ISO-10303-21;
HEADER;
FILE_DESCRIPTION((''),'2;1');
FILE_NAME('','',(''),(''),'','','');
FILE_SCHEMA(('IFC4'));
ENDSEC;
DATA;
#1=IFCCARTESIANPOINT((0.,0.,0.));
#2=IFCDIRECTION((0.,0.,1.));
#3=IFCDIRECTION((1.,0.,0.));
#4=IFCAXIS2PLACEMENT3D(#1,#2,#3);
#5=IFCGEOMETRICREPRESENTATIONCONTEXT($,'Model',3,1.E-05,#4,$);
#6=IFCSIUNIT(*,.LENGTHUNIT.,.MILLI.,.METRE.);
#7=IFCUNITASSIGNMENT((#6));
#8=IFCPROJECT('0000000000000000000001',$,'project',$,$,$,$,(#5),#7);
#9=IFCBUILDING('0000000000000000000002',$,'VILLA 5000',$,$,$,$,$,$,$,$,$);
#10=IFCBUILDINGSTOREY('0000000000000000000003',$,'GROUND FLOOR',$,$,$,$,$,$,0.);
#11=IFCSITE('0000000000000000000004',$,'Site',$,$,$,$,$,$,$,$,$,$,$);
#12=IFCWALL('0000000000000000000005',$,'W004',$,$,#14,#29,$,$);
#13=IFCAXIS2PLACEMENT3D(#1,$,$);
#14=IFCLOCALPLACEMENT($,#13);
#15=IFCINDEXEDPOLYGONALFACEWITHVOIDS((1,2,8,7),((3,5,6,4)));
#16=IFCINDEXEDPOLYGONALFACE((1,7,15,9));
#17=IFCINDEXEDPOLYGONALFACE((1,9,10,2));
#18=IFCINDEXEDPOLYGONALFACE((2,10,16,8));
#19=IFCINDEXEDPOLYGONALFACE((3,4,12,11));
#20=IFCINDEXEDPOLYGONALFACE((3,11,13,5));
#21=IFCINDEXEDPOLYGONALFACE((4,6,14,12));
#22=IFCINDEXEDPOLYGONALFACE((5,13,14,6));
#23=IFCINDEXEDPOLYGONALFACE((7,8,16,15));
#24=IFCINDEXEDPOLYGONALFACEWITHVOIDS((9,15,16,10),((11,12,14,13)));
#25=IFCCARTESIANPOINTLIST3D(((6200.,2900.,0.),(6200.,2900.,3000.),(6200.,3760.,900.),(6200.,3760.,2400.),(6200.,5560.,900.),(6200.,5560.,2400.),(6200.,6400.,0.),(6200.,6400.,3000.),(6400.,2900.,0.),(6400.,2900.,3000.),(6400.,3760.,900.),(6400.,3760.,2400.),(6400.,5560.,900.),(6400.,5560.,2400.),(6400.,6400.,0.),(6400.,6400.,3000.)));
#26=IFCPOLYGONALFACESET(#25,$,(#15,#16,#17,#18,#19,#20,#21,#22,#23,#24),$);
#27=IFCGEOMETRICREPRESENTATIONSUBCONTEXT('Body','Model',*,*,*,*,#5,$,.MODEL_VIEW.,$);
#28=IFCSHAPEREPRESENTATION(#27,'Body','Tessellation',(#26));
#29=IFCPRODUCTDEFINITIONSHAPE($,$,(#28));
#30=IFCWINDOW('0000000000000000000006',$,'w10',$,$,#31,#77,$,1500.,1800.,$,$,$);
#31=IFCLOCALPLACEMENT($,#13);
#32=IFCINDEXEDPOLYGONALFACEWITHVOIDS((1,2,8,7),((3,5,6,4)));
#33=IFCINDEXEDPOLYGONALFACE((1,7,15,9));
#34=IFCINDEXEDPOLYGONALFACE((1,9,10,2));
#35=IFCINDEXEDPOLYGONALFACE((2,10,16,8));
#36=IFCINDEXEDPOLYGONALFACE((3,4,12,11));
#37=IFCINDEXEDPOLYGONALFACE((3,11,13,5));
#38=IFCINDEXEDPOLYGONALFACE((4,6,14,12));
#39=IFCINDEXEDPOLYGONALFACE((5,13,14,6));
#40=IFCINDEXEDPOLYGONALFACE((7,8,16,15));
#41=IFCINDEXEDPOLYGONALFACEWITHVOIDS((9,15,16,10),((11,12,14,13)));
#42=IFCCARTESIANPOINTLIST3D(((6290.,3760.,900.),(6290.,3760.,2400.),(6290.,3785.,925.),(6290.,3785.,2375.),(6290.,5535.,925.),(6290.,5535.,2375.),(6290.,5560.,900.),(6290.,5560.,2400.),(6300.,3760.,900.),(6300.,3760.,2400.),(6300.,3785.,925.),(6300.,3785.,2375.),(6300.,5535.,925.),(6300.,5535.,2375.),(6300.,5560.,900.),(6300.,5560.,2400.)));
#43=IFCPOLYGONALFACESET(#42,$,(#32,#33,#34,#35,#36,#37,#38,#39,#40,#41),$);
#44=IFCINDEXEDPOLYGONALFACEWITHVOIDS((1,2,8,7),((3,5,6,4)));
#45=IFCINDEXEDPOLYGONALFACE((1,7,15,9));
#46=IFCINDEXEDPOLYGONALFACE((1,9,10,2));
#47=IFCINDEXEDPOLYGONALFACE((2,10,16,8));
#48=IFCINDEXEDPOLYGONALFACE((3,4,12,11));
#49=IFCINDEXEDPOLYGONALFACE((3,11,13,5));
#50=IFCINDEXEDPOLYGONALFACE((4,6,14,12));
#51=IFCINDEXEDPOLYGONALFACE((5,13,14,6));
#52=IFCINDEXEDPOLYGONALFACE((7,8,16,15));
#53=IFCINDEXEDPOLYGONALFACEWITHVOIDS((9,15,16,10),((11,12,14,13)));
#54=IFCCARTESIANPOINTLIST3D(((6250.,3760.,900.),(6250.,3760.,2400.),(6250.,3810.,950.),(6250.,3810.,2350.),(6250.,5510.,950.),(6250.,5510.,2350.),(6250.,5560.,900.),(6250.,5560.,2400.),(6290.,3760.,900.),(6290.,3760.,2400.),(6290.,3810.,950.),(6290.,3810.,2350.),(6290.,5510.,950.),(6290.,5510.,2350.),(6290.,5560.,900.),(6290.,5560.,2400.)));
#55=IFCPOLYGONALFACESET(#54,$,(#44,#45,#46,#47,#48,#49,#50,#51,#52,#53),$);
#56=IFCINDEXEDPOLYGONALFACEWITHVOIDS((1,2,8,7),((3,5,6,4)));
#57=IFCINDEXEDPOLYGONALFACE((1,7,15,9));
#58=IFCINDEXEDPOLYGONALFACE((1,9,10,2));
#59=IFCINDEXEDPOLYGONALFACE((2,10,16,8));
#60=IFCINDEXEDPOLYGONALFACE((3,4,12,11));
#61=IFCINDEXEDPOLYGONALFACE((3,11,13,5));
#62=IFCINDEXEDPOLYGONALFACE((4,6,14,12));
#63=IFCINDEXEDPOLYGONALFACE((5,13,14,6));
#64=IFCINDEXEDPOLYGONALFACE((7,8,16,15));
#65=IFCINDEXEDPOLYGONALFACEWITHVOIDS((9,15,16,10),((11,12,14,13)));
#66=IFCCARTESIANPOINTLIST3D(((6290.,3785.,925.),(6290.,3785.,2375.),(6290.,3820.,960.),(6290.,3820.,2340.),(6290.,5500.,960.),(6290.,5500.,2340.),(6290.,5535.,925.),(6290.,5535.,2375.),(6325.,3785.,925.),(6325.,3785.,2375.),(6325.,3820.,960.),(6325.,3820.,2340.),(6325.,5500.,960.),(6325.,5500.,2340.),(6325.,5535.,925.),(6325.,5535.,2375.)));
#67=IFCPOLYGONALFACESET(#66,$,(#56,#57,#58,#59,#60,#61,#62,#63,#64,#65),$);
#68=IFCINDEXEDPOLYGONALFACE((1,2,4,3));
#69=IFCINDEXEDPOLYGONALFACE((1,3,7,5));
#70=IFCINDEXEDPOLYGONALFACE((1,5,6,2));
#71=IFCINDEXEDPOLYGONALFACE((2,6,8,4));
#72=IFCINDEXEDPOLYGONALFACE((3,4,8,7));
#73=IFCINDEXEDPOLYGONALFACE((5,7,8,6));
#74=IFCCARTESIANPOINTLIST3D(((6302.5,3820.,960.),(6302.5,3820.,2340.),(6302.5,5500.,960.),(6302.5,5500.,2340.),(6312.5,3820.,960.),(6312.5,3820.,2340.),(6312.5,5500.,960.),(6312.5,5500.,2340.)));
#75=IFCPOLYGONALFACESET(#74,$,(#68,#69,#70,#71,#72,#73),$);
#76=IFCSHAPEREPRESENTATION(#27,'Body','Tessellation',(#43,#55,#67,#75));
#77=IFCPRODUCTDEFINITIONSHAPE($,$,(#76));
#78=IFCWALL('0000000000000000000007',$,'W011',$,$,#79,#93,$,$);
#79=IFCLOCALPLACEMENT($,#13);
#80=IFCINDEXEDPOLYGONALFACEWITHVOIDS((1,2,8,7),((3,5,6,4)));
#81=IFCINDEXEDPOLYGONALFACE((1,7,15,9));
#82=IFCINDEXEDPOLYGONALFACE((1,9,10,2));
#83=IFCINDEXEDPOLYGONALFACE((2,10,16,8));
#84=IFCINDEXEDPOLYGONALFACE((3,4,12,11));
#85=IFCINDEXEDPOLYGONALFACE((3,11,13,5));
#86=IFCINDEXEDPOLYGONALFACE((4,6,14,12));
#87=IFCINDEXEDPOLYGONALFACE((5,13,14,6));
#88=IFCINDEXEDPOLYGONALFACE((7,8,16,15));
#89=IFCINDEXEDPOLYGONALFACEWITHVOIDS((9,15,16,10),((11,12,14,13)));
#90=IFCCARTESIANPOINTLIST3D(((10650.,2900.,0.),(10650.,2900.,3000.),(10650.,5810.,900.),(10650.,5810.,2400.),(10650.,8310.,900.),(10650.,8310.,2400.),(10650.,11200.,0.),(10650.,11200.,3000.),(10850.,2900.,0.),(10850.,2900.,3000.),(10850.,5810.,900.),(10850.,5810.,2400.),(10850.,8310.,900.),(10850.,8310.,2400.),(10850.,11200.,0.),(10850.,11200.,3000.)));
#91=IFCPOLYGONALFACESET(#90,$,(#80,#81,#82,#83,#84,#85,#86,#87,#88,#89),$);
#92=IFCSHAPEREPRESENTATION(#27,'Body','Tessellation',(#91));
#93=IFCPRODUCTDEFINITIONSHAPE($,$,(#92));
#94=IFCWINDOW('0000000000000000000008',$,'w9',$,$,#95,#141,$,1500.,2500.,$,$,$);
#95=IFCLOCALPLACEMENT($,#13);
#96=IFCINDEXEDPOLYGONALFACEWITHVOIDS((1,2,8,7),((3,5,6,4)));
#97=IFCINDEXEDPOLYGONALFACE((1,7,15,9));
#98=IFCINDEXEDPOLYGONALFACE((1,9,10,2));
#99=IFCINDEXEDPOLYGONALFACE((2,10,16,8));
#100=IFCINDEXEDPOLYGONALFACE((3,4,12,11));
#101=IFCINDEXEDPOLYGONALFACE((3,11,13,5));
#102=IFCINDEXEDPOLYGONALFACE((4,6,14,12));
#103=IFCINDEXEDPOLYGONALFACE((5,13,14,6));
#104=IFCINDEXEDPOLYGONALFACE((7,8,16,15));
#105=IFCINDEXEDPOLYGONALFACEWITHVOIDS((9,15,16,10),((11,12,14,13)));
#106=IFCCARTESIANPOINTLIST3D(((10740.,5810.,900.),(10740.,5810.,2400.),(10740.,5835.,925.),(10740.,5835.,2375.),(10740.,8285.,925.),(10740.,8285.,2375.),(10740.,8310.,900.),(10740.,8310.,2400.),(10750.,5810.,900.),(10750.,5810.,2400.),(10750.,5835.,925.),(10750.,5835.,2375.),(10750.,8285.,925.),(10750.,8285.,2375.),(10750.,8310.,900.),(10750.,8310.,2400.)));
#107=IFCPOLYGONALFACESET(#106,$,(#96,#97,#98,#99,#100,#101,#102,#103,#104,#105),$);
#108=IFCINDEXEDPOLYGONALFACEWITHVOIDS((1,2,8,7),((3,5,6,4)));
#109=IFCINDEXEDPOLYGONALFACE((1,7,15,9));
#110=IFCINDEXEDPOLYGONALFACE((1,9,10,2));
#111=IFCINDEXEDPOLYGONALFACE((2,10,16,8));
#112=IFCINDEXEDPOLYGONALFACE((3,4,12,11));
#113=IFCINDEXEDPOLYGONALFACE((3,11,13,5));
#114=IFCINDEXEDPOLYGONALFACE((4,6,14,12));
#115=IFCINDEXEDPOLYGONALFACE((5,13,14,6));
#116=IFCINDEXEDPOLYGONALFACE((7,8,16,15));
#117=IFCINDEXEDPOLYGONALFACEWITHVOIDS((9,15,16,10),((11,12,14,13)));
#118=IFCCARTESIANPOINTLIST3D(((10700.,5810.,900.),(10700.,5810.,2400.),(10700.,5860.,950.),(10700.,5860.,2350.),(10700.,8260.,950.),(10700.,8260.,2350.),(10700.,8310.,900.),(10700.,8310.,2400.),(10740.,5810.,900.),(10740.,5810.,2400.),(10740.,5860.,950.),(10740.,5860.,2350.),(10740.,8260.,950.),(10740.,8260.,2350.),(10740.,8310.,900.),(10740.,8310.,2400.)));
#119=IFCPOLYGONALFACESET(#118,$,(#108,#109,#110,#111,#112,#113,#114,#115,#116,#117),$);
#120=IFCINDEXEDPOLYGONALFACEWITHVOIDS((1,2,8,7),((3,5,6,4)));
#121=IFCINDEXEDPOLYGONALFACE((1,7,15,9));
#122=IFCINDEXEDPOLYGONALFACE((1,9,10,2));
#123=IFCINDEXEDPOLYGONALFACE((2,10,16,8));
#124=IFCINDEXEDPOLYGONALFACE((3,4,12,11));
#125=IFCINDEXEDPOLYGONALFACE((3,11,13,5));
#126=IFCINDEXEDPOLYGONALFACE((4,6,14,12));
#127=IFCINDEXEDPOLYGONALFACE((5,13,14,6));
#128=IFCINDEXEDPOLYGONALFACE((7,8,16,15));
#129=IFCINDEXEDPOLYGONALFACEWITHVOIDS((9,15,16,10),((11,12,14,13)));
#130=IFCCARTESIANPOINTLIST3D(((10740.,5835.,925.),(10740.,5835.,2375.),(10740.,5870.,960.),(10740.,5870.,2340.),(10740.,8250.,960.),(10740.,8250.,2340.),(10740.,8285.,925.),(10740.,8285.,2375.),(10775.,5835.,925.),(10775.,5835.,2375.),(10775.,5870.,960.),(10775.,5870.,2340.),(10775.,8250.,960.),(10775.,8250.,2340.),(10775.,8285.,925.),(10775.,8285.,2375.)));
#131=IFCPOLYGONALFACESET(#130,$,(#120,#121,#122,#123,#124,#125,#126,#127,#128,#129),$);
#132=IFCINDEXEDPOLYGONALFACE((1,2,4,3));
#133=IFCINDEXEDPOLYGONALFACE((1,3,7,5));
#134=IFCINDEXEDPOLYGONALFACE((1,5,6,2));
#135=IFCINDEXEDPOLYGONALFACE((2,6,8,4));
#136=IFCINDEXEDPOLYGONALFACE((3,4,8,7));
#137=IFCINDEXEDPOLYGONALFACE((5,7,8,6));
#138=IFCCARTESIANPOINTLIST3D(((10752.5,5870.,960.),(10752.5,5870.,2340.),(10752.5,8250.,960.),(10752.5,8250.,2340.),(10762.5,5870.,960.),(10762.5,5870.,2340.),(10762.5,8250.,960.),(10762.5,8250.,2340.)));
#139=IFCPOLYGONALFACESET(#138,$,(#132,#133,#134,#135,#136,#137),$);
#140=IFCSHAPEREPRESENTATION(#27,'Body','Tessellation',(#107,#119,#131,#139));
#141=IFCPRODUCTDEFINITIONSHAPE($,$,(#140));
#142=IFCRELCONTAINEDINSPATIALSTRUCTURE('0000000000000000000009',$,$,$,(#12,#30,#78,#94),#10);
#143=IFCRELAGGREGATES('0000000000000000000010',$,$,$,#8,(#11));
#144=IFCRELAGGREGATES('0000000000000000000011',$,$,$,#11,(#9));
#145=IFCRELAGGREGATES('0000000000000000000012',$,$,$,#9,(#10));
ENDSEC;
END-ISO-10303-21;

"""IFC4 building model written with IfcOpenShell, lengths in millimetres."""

from ifc_helpers import new_model, si_unit, frame, origin_with_axes, place, context, subcontext, project, spatial, line, indexed_curve, outline, extrude, element, fill, save


model = new_model("IFC4")

# Units and contexts
model_context = context("Model", 3, precision=1e-05, world=origin_with_axes())
body_context = subcontext(model_context, "Body", "Model", "MODEL_VIEW")
ifc_project = project(units=[si_unit("LENGTHUNIT", "METRE", prefix="MILLI")], contexts=[model_context])

# Site, building, storey
site = spatial("IfcSite", under=ifc_project, Name="Site")
building = spatial("IfcBuilding", under=site, Name="VILLA 5000")
storey = spatial("IfcBuildingStorey", under=building, Name="GROUND FLOOR", Elevation=0.0)

# Wall, opening, window
wall_1_placement = place(None, frame((6300.0, 6400.0, 0.0), z_axis=(0.0, 0.0, 1.0), x_axis=(0.0, -1.0, 0.0)))
wall_1 = element("IfcWall", 1, at=wall_1_placement, inside=storey, Name="W004", context=body_context, shape_type="SweptSolid", body=[
    extrude(outline(indexed_curve([(0.0, 0.0), (0.0, 200.0), (3500.0, 200.0), (3500.0, 0.0), (0.0, 0.0)], self_intersect=False)), frame((0.0, -100.0, 0.0), z_axis=(0.0, 0.0, 1.0), x_axis=(1.0, 0.0, 0.0)), (0.0, 0.0, 1.0), 3000.0),
])
opening_1_placement = place(wall_1_placement, frame((840.0, 0.0, 900.0), z_axis=(0.0, 0.0, 1.0), x_axis=(1.0, 0.0, 0.0)))
opening_1 = element("IfcOpeningElement", 2, at=opening_1_placement, cuts=wall_1, context=body_context, shape_type="SweptSolid", body=[
    extrude(outline(indexed_curve([(0.0, 0.0), (0.0, 300.0), (1800.0, 300.0), (1800.0, 0.0), (0.0, 0.0)], self_intersect=False)), frame((0.0, -150.0, 0.0), z_axis=(0.0, 0.0, 1.0), x_axis=(1.0, 0.0, 0.0)), (0.0, 0.0, 1.0), 1500.0),
])
window_1_placement = place(None, frame((6200.0, 5560.0, 900.0), z_axis=(0.0, 0.0, 1.0), x_axis=(0.0, -1.0, 0.0)))
window_1 = element("IfcWindow", 3, at=window_1_placement, inside=storey, Name="w10", OverallHeight=1500.0, OverallWidth=1800.0, context=body_context, shape_type="SweptSolid", body=[
    extrude(outline(indexed_curve([(0.0, 0.0), (1800.0, 0.0), (1800.0, 1500.0), (0.0, 1500.0)], segments=[line(1, 2, 3, 4, 1)]), holes=[indexed_curve([(25.0, 25.0), (1775.0, 25.0), (1775.0, 1475.0), (25.0, 1475.0)], segments=[line(1, 2, 3, 4, 1)])]), frame((0.0, 90.0, 0.0), z_axis=(0.0, -1.0, 0.0), x_axis=(1.0, 0.0, 0.0)), (0.0, 0.0, -1.0), 10.0),
    extrude(outline(indexed_curve([(0.0, 0.0), (1800.0, 0.0), (1800.0, 1500.0), (0.0, 1500.0)], segments=[line(1, 2, 3, 4, 1)]), holes=[indexed_curve([(50.0, 50.0), (1750.0, 50.0), (1750.0, 1450.0), (50.0, 1450.0)], segments=[line(1, 2, 3, 4, 1)])]), frame((0.0, 50.0, 0.0), z_axis=(0.0, -1.0, 0.0), x_axis=(1.0, 0.0, 0.0)), (0.0, 0.0, -1.0), 40.0),
    extrude(outline(indexed_curve([(0.0, 0.0), (1750.0, 0.0), (1750.0, 1450.0), (0.0, 1450.0)], segments=[line(1, 2, 3, 4, 1)]), holes=[indexed_curve([(35.0, 35.0), (1715.0, 35.0), (1715.0, 1415.0), (35.0, 1415.0)], segments=[line(1, 2, 3, 4, 1)])]), frame((25.0, 90.0, 25.0), z_axis=(0.0, -1.0, 0.0), x_axis=(1.0, 0.0, 0.0)), (0.0, 0.0, -1.0), 35.0),
    extrude(outline(indexed_curve([(35.0, 35.0), (1715.0, 35.0), (1715.0, 1415.0), (35.0, 1415.0)], segments=[line(1, 2, 3, 4, 1)])), frame((25.0, 102.5, 25.0), z_axis=(0.0, -1.0, 0.0), x_axis=(1.0, 0.0, 0.0)), (0.0, 0.0, -1.0), 10.0),
])
fill(opening_1, window_1)

# Wall, opening, window
wall_2_placement = place(None, frame((10750.0, 11200.0, 0.0), z_axis=(0.0, 0.0, 1.0), x_axis=(0.0, -1.0, 0.0)))
wall_2 = element("IfcWall", 4, at=wall_2_placement, inside=storey, Name="W011", context=body_context, shape_type="SweptSolid", body=[
    extrude(outline(indexed_curve([(0.0, 0.0), (0.0, 200.0), (8300.0, 200.0), (8300.0, 0.0), (0.0, 0.0)], self_intersect=False)), frame((0.0, -100.0, 0.0), z_axis=(0.0, 0.0, 1.0), x_axis=(1.0, 0.0, 0.0)), (0.0, 0.0, 1.0), 3000.0),
])
opening_2_placement = place(wall_2_placement, frame((2890.0, 0.0, 900.0), z_axis=(0.0, 0.0, 1.0), x_axis=(1.0, 0.0, 0.0)))
opening_2 = element("IfcOpeningElement", 5, at=opening_2_placement, cuts=wall_2, context=body_context, shape_type="SweptSolid", body=[
    extrude(outline(indexed_curve([(0.0, 0.0), (0.0, 300.0), (2500.0, 300.0), (2500.0, 0.0), (0.0, 0.0)], self_intersect=False)), frame((0.0, -150.0, 0.0), z_axis=(0.0, 0.0, 1.0), x_axis=(1.0, 0.0, 0.0)), (0.0, 0.0, 1.0), 1500.0),
])
window_2_placement = place(None, frame((10650.0, 8310.0, 900.0), z_axis=(0.0, 0.0, 1.0), x_axis=(0.0, -1.0, 0.0)))
window_2 = element("IfcWindow", 6, at=window_2_placement, inside=storey, Name="w9", OverallHeight=1500.0, OverallWidth=2500.0, context=body_context, shape_type="SweptSolid", body=[
    extrude(outline(indexed_curve([(0.0, 0.0), (2500.0, 0.0), (2500.0, 1500.0), (0.0, 1500.0)], segments=[line(1, 2, 3, 4, 1)]), holes=[indexed_curve([(25.0, 25.0), (2475.0, 25.0), (2475.0, 1475.0), (25.0, 1475.0)], segments=[line(1, 2, 3, 4, 1)])]), frame((0.0, 90.0, 0.0), z_axis=(0.0, -1.0, 0.0), x_axis=(1.0, 0.0, 0.0)), (0.0, 0.0, -1.0), 10.0),
    extrude(outline(indexed_curve([(0.0, 0.0), (2500.0, 0.0), (2500.0, 1500.0), (0.0, 1500.0)], segments=[line(1, 2, 3, 4, 1)]), holes=[indexed_curve([(50.0, 50.0), (2450.0, 50.0), (2450.0, 1450.0), (50.0, 1450.0)], segments=[line(1, 2, 3, 4, 1)])]), frame((0.0, 50.0, 0.0), z_axis=(0.0, -1.0, 0.0), x_axis=(1.0, 0.0, 0.0)), (0.0, 0.0, -1.0), 40.0),
    extrude(outline(indexed_curve([(0.0, 0.0), (2450.0, 0.0), (2450.0, 1450.0), (0.0, 1450.0)], segments=[line(1, 2, 3, 4, 1)]), holes=[indexed_curve([(35.0, 35.0), (2415.0, 35.0), (2415.0, 1415.0), (35.0, 1415.0)], segments=[line(1, 2, 3, 4, 1)])]), frame((25.0, 90.0, 25.0), z_axis=(0.0, -1.0, 0.0), x_axis=(1.0, 0.0, 0.0)), (0.0, 0.0, -1.0), 35.0),
    extrude(outline(indexed_curve([(35.0, 35.0), (2415.0, 35.0), (2415.0, 1415.0), (35.0, 1415.0)], segments=[line(1, 2, 3, 4, 1)])), frame((25.0, 102.5, 25.0), z_axis=(0.0, -1.0, 0.0), x_axis=(1.0, 0.0, 0.0)), (0.0, 0.0, -1.0), 10.0),
])
fill(opening_2, window_2)

save(model, "model.ifc")
